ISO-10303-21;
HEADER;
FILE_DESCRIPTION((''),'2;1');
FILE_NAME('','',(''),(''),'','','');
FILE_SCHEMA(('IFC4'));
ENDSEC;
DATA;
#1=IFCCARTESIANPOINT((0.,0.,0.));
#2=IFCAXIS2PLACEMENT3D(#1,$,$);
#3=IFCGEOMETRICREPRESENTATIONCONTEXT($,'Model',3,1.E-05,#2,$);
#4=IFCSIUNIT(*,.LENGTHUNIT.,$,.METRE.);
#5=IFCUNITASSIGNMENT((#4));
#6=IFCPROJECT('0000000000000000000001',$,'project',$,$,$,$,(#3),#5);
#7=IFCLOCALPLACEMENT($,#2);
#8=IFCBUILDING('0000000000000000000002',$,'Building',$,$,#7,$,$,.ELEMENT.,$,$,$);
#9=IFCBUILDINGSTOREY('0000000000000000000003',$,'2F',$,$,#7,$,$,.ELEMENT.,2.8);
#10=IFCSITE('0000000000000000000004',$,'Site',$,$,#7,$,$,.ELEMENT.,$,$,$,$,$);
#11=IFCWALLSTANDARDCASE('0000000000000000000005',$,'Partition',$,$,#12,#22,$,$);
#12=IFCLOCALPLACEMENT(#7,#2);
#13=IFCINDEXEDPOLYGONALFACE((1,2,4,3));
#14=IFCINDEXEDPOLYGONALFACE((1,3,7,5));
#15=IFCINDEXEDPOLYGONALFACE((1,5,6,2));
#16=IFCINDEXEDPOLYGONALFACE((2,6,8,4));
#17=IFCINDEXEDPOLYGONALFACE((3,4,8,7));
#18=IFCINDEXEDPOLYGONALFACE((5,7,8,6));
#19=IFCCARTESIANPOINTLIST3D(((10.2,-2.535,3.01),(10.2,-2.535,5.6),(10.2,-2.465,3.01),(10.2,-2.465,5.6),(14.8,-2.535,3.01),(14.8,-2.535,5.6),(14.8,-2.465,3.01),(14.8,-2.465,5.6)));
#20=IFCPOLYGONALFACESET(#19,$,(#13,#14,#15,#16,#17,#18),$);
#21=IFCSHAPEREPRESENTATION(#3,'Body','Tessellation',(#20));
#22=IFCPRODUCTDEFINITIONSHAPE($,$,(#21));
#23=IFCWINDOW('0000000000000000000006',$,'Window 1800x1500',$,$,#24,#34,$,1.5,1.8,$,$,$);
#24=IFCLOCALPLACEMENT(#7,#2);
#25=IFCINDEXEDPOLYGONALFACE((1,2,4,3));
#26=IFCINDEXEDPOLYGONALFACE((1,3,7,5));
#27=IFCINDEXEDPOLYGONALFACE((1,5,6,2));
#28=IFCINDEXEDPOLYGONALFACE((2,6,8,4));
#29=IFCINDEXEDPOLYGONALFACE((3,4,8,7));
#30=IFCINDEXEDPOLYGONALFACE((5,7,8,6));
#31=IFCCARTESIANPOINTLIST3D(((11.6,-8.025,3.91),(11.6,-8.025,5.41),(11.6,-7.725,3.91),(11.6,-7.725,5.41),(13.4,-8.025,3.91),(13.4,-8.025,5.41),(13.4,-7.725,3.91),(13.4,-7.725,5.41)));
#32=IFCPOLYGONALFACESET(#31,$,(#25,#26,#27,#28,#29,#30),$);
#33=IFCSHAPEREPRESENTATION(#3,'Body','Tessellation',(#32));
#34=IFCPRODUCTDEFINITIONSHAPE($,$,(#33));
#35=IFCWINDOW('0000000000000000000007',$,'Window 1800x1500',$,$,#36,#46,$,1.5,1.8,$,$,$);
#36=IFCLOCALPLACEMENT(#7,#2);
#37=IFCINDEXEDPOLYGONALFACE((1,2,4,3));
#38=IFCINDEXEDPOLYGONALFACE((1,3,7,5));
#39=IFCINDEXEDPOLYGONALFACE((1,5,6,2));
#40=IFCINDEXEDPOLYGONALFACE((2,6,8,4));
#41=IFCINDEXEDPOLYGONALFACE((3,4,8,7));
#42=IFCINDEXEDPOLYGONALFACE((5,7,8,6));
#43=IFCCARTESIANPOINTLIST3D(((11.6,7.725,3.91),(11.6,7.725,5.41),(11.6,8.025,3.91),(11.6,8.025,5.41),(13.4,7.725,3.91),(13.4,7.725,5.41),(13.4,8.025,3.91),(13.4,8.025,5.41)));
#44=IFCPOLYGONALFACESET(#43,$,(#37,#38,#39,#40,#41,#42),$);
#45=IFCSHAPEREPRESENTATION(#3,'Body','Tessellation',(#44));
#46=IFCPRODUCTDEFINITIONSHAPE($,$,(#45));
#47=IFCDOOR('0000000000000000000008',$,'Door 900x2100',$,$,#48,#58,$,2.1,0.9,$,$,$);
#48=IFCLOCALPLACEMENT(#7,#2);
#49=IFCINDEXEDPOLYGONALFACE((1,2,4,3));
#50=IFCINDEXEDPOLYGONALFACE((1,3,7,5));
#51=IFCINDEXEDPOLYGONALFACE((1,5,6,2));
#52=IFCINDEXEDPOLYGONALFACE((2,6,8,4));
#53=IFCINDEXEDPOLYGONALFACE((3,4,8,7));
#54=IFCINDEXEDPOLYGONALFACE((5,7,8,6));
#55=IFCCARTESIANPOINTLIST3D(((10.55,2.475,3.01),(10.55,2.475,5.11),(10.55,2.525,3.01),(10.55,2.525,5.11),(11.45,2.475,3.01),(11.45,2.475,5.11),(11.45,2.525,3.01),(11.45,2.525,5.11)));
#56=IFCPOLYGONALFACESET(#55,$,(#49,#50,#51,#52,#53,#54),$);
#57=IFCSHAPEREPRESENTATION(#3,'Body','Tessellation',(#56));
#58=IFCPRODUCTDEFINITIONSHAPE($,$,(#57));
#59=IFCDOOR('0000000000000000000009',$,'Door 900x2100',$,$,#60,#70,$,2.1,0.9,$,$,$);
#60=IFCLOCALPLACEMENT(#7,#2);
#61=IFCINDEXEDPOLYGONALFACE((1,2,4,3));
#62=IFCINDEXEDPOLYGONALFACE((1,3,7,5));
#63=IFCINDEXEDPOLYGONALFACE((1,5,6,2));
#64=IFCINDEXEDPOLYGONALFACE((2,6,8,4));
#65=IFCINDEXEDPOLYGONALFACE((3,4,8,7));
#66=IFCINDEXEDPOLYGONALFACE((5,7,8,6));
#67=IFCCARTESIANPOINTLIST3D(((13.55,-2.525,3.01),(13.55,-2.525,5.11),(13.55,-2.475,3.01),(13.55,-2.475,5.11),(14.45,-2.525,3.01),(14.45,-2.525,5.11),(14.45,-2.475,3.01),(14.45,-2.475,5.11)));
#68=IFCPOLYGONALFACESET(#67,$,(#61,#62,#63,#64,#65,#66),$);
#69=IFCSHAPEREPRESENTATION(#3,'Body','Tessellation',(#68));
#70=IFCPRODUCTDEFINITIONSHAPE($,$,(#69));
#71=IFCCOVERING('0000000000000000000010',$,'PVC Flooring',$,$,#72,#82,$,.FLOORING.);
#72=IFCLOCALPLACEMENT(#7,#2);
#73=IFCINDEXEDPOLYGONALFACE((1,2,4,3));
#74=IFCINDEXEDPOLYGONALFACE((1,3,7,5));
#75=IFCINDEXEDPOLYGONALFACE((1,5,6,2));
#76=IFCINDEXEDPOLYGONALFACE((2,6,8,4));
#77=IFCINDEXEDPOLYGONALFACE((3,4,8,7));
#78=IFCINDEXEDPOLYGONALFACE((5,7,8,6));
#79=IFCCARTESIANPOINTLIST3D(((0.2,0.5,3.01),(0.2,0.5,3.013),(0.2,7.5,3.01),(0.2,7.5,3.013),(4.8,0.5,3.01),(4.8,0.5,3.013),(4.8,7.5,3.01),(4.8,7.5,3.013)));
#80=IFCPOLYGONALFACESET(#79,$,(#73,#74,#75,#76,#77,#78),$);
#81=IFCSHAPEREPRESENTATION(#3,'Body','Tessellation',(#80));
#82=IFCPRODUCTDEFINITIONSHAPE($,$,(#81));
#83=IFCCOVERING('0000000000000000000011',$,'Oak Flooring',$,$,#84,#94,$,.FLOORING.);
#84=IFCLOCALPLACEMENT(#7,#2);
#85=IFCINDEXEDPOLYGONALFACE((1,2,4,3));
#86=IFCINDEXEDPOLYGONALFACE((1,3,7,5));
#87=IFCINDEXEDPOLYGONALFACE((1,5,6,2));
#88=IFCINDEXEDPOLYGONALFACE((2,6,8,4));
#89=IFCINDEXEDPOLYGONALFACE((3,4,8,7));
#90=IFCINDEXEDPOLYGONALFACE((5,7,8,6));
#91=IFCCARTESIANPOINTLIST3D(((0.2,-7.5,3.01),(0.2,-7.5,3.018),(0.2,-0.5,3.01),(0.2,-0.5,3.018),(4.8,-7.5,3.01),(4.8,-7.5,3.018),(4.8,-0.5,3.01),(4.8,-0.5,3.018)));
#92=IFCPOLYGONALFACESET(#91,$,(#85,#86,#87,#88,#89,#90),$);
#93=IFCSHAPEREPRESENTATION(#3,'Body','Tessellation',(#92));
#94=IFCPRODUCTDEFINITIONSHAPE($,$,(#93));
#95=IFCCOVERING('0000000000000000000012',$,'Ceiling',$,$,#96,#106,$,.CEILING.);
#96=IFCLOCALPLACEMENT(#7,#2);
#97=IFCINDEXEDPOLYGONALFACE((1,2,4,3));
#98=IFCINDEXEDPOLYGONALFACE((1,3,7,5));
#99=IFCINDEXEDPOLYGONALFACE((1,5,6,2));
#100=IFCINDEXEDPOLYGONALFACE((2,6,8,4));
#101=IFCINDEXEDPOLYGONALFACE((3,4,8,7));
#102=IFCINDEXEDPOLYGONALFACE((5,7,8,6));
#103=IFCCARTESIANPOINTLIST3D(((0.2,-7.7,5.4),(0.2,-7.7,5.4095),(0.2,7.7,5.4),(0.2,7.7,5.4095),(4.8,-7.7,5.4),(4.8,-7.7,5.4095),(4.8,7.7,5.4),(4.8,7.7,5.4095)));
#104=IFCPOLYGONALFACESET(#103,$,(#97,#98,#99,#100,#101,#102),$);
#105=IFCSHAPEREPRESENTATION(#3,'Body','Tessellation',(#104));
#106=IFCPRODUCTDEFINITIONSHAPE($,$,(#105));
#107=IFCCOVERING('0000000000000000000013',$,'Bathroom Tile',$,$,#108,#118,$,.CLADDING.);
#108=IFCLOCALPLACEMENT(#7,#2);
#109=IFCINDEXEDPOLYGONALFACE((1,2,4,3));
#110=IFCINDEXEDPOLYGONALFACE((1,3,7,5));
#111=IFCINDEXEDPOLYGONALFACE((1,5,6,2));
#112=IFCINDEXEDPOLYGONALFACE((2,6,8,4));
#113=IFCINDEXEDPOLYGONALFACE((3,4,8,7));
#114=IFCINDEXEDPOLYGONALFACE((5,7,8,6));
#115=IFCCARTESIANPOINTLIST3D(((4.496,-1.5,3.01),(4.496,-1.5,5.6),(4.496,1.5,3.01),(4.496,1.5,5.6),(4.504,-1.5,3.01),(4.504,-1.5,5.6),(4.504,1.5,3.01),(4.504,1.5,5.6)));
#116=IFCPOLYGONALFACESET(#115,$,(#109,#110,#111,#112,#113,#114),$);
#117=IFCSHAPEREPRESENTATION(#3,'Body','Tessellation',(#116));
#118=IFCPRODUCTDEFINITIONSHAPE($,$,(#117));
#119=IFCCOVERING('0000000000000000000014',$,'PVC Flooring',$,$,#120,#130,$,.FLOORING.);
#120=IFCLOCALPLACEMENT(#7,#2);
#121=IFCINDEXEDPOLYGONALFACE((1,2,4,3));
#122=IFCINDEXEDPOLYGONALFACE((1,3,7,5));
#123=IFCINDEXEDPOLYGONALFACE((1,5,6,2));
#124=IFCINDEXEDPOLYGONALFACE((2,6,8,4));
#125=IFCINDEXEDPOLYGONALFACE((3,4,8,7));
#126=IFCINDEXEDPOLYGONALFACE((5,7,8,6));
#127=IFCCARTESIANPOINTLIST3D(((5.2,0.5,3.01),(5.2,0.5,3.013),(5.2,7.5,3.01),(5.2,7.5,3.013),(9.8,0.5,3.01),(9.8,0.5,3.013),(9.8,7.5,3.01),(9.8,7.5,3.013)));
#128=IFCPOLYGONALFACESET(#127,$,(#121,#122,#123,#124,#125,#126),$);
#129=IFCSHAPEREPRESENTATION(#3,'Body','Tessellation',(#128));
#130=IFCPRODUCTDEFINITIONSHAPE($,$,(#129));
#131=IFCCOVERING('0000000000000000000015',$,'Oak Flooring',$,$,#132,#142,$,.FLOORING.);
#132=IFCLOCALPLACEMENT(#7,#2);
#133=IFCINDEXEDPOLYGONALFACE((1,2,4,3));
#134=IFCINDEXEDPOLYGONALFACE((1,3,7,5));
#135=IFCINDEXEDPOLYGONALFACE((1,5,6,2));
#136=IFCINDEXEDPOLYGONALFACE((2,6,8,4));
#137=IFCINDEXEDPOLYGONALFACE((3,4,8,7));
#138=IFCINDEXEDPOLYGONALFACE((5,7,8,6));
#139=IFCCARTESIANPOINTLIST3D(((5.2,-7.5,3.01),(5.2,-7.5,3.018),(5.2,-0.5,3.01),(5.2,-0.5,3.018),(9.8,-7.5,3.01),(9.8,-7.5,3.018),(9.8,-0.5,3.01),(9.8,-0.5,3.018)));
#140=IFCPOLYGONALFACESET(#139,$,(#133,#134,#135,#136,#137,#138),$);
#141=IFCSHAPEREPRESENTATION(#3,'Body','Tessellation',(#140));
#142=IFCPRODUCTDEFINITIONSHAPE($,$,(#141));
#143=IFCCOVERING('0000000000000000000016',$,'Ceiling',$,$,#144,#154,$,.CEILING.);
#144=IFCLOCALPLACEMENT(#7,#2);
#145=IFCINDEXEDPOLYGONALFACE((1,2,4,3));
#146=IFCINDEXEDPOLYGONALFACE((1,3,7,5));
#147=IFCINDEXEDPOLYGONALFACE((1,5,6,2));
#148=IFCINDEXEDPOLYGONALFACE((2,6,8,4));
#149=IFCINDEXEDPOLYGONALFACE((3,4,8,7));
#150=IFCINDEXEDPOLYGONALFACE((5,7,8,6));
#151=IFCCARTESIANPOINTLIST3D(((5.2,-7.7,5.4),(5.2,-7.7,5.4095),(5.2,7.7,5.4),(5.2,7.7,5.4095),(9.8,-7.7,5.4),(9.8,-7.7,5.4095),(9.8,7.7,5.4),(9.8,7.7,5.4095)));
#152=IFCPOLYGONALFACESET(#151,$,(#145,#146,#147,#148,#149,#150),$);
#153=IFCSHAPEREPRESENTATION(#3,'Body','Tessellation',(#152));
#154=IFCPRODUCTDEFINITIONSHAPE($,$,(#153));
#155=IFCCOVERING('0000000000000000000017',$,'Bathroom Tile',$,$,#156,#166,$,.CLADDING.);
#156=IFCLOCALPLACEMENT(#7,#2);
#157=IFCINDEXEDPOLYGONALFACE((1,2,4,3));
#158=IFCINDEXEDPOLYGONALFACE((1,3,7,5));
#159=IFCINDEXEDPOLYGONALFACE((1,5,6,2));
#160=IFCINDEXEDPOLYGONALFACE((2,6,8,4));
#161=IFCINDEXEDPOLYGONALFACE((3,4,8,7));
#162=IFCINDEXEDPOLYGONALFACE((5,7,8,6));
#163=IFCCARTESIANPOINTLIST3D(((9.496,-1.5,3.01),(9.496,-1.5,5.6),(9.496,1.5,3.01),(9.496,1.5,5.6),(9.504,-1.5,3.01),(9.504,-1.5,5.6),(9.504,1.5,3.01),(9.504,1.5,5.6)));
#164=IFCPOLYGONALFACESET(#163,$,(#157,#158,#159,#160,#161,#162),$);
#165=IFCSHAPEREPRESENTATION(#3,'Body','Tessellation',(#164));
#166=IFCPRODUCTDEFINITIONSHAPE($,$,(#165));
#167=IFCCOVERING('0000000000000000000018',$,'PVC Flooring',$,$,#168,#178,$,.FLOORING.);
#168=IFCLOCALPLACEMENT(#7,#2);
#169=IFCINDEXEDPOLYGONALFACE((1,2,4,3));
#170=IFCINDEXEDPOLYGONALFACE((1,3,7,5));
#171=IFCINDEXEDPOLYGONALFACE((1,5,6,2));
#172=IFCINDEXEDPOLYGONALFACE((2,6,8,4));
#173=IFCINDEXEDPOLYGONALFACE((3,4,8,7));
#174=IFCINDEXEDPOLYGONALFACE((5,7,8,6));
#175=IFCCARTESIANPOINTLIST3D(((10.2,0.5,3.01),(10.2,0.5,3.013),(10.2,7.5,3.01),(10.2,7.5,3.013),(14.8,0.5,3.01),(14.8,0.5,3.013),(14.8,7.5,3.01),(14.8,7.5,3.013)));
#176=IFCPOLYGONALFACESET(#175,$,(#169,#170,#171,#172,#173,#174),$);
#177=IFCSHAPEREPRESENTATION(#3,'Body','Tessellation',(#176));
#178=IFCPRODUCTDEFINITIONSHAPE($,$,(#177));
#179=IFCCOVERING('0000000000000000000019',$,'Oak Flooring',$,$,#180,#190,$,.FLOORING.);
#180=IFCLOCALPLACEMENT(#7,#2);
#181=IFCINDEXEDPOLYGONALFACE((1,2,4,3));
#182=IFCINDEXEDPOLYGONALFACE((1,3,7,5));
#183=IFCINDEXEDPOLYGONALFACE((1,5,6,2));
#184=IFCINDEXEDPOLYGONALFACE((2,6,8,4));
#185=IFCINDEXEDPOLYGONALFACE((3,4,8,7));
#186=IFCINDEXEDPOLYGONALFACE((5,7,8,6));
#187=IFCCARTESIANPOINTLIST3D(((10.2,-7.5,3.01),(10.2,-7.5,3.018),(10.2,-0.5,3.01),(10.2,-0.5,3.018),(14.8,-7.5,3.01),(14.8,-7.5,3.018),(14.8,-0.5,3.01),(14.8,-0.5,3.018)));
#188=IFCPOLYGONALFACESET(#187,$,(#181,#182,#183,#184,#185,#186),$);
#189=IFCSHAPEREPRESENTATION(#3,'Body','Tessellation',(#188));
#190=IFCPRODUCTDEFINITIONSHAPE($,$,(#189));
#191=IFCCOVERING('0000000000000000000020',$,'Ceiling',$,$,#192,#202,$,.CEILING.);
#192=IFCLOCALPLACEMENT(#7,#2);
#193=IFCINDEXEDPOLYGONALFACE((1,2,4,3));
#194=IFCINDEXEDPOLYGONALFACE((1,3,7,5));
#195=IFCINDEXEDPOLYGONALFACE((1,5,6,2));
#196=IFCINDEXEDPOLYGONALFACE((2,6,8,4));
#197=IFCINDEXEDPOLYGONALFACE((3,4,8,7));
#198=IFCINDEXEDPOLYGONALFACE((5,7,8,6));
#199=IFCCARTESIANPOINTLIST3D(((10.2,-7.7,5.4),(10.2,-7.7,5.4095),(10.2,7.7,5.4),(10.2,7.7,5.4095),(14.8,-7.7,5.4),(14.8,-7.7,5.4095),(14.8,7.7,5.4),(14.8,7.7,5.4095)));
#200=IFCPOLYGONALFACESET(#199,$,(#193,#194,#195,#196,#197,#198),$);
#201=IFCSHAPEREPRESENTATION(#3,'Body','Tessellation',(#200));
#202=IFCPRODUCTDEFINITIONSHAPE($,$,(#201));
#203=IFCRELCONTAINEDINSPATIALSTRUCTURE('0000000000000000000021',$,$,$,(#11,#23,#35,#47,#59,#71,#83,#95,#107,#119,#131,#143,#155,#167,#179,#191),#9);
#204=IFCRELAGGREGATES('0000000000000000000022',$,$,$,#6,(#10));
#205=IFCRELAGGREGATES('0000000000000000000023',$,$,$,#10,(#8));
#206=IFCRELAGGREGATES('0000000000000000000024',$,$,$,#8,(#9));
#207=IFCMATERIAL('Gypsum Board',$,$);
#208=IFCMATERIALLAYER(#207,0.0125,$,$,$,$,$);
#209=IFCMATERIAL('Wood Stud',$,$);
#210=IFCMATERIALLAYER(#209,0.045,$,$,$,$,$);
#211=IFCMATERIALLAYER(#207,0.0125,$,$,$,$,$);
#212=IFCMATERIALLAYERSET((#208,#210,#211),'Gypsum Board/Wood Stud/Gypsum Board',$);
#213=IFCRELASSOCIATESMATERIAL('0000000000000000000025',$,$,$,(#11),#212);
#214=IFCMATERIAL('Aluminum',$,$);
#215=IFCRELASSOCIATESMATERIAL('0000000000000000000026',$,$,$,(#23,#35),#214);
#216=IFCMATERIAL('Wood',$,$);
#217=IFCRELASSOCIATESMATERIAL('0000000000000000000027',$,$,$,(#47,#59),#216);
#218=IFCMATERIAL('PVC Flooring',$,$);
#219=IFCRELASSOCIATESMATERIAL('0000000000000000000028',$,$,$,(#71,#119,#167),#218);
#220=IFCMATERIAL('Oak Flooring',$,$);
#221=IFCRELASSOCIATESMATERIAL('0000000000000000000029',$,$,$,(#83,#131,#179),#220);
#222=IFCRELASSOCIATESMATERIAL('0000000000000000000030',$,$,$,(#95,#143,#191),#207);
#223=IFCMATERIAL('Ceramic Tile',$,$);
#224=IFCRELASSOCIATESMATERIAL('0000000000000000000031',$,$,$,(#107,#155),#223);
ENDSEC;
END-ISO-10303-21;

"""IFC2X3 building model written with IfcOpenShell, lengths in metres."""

from ifc_helpers import new_model, si_unit, frame, origin, origin_2d, place, context, project, spatial, rectangle, extrude, material, layer, layer_set, layer_usage, element, save


model = new_model("IFC2X3")

# Units and contexts
model_context = context("Model", 3, precision=1e-05, world=origin())
ifc_project = project(units=[si_unit("LENGTHUNIT", "METRE")], contexts=[model_context])

# Site, building, storey
placement = place(None, origin())
site = spatial("IfcSite", under=ifc_project, at=placement, Name="Site", CompositionType="ELEMENT")
building = spatial("IfcBuilding", under=site, at=placement, Name="Building", CompositionType="ELEMENT")
storey = spatial("IfcBuildingStorey", under=building, at=placement, Name="2F", CompositionType="ELEMENT", Elevation=2.8)

# Shared definitions
ifc_material_1 = material(Name="Gypsum Board")
ifc_layer_1 = layer(ifc_material_1, 0.0125)
ifc_material_2 = material(Name="Wood Stud")
ifc_layer_2 = layer(ifc_material_2, 0.045)
ifc_layer_3 = layer(ifc_material_1, 0.0125)
ifc_layer_set_1 = layer_set([ifc_layer_1, ifc_layer_2, ifc_layer_3], Name="Gypsum Board/Wood Stud/Gypsum Board")
ifc_layer_usage_1 = layer_usage(ifc_layer_set_1, "AXIS2", "POSITIVE", 0.0)

# Shared definitions
ifc_material_3 = material(Name="Aluminum")

# Shared definitions
ifc_material_4 = material(Name="Wood")

# Wall
for number, where, name in (
    (1, (12.5, -2.5, 3.01), "Partition"),
):
    element("IfcWallStandardCase", number, at=place(None, frame(where)), inside=storey, material=ifc_layer_usage_1, Name=name, context=model_context, shape_type="SweptSolid", body=[
        extrude(rectangle(XDim=4.6, YDim=0.07, at=origin_2d()), origin(), (0.0, 0.0, 1.0), 2.59),
    ])

# Windows
for number, where, name in (
    (2, (12.5, -7.875, 3.91), "Window 1800x1500"),
    (3, (12.5, 7.875, 3.91), "Window 1800x1500"),
):
    element("IfcWindow", number, at=place(None, frame(where)), inside=storey, material=ifc_material_3, Name=name, OverallHeight=1.5, OverallWidth=1.8, context=model_context, shape_type="SweptSolid", body=[
        extrude(rectangle(XDim=1.8, YDim=0.3, at=origin_2d()), origin(), (0.0, 0.0, 1.0), 1.5),
    ])

# Doors
for number, where, name in (
    (4, (11.0, 2.5, 3.01), "Door 900x2100"),
    (5, (14.0, -2.5, 3.01), "Door 900x2100"),
):
    element("IfcDoor", number, at=place(None, frame(where)), inside=storey, material=ifc_material_4, Name=name, OverallHeight=2.1, OverallWidth=0.9, context=model_context, shape_type="SweptSolid", body=[
        extrude(rectangle(XDim=0.9, YDim=0.05, at=origin_2d()), origin(), (0.0, 0.0, 1.0), 2.1),
    ])

# Coverings
ifc_material_5 = material(Name="PVC Flooring")
covering_1_placement = place(None, frame((2.5, 4.0, 3.01)))
element("IfcCovering", 6, at=covering_1_placement, inside=storey, material=ifc_material_5, Name="PVC Flooring", PredefinedType="FLOORING", context=model_context, shape_type="SweptSolid", body=[
    extrude(rectangle(XDim=4.6, YDim=7.0, at=origin_2d()), origin(), (0.0, 0.0, 1.0), 0.003),
])
ifc_material_6 = material(Name="Oak Flooring")
covering_2_placement = place(None, frame((2.5, -4.0, 3.01)))
element("IfcCovering", 7, at=covering_2_placement, inside=storey, material=ifc_material_6, Name="Oak Flooring", PredefinedType="FLOORING", context=model_context, shape_type="SweptSolid", body=[
    extrude(rectangle(XDim=4.6, YDim=7.0, at=origin_2d()), origin(), (0.0, 0.0, 1.0), 0.008),
])
covering_3_placement = place(None, frame((2.5, 0.0, 5.4)))
element("IfcCovering", 8, at=covering_3_placement, inside=storey, material=ifc_material_1, Name="Ceiling", PredefinedType="CEILING", context=model_context, shape_type="SweptSolid", body=[
    extrude(rectangle(XDim=4.6, YDim=15.4, at=origin_2d()), origin(), (0.0, 0.0, 1.0), 0.0095),
])
ifc_material_7 = material(Name="Ceramic Tile")
covering_4_placement = place(None, frame((4.5, 0.0, 3.01)))
element("IfcCovering", 9, at=covering_4_placement, inside=storey, material=ifc_material_7, Name="Bathroom Tile", PredefinedType="CLADDING", context=model_context, shape_type="SweptSolid", body=[
    extrude(rectangle(XDim=0.008, YDim=3.0, at=origin_2d()), origin(), (0.0, 0.0, 1.0), 2.59),
])
covering_5_placement = place(None, frame((7.5, 4.0, 3.01)))
element("IfcCovering", 10, at=covering_5_placement, inside=storey, material=ifc_material_5, Name="PVC Flooring", PredefinedType="FLOORING", context=model_context, shape_type="SweptSolid", body=[
    extrude(rectangle(XDim=4.6, YDim=7.0, at=origin_2d()), origin(), (0.0, 0.0, 1.0), 0.003),
])
covering_6_placement = place(None, frame((7.5, -4.0, 3.01)))
element("IfcCovering", 11, at=covering_6_placement, inside=storey, material=ifc_material_6, Name="Oak Flooring", PredefinedType="FLOORING", context=model_context, shape_type="SweptSolid", body=[
    extrude(rectangle(XDim=4.6, YDim=7.0, at=origin_2d()), origin(), (0.0, 0.0, 1.0), 0.008),
])
covering_7_placement = place(None, frame((7.5, 0.0, 5.4)))
element("IfcCovering", 12, at=covering_7_placement, inside=storey, material=ifc_material_1, Name="Ceiling", PredefinedType="CEILING", context=model_context, shape_type="SweptSolid", body=[
    extrude(rectangle(XDim=4.6, YDim=15.4, at=origin_2d()), origin(), (0.0, 0.0, 1.0), 0.0095),
])
covering_8_placement = place(None, frame((9.5, 0.0, 3.01)))
element("IfcCovering", 13, at=covering_8_placement, inside=storey, material=ifc_material_7, Name="Bathroom Tile", PredefinedType="CLADDING", context=model_context, shape_type="SweptSolid", body=[
    extrude(rectangle(XDim=0.008, YDim=3.0, at=origin_2d()), origin(), (0.0, 0.0, 1.0), 2.59),
])
covering_9_placement = place(None, frame((12.5, 4.0, 3.01)))
element("IfcCovering", 14, at=covering_9_placement, inside=storey, material=ifc_material_5, Name="PVC Flooring", PredefinedType="FLOORING", context=model_context, shape_type="SweptSolid", body=[
    extrude(rectangle(XDim=4.6, YDim=7.0, at=origin_2d()), origin(), (0.0, 0.0, 1.0), 0.003),
])
covering_10_placement = place(None, frame((12.5, -4.0, 3.01)))
element("IfcCovering", 15, at=covering_10_placement, inside=storey, material=ifc_material_6, Name="Oak Flooring", PredefinedType="FLOORING", context=model_context, shape_type="SweptSolid", body=[
    extrude(rectangle(XDim=4.6, YDim=7.0, at=origin_2d()), origin(), (0.0, 0.0, 1.0), 0.008),
])
covering_11_placement = place(None, frame((12.5, 0.0, 5.4)))
element("IfcCovering", 16, at=covering_11_placement, inside=storey, material=ifc_material_1, Name="Ceiling", PredefinedType="CEILING", context=model_context, shape_type="SweptSolid", body=[
    extrude(rectangle(XDim=4.6, YDim=15.4, at=origin_2d()), origin(), (0.0, 0.0, 1.0), 0.0095),
])

save(model, "model.ifc")
